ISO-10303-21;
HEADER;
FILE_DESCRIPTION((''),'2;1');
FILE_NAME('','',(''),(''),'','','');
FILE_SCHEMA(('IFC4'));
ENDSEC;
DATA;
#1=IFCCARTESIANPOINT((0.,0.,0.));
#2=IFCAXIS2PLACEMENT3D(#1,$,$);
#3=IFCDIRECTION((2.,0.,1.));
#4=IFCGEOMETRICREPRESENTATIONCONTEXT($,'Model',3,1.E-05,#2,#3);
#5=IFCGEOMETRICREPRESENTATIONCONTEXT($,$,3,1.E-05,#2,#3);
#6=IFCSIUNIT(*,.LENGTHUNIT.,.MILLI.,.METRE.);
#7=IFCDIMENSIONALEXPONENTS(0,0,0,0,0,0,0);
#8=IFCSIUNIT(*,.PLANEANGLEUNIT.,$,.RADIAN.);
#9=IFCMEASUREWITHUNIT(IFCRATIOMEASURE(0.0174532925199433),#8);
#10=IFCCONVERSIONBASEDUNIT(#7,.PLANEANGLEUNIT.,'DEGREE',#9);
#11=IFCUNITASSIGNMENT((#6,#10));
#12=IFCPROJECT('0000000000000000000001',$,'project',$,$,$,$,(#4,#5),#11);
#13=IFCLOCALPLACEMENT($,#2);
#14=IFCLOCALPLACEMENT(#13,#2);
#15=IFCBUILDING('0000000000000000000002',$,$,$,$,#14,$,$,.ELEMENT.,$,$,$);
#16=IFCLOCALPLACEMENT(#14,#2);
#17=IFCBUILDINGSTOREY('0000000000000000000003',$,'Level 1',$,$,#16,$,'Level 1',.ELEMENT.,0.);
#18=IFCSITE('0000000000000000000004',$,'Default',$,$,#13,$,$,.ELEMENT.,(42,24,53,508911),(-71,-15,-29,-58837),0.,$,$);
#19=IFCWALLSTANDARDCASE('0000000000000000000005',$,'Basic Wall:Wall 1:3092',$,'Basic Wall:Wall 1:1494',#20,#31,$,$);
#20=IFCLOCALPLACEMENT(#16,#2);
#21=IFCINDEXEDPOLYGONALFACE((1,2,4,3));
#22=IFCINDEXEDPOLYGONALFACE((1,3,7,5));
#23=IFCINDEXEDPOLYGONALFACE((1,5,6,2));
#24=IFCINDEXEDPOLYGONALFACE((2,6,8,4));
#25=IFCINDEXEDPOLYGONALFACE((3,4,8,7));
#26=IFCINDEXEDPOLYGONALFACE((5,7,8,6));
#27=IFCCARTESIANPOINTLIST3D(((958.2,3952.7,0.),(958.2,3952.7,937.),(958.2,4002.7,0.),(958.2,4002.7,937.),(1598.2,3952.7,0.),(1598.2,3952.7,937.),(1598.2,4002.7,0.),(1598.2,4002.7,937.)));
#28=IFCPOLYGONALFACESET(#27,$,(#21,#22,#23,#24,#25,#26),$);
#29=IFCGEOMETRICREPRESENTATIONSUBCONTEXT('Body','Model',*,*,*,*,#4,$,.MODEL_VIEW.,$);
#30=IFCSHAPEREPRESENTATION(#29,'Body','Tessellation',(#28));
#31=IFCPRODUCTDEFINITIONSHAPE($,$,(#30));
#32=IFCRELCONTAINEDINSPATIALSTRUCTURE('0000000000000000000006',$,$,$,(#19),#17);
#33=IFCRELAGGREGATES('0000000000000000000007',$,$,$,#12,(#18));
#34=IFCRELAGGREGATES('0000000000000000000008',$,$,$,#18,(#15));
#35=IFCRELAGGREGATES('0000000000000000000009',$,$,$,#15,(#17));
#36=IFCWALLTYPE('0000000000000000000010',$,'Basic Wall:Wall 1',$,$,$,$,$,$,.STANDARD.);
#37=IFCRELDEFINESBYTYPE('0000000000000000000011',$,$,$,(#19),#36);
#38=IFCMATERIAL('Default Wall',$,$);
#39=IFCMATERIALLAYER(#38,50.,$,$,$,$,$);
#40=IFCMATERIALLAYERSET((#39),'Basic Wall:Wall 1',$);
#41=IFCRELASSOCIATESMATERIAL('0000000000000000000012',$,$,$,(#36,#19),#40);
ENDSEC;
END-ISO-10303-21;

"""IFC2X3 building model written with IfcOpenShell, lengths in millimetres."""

from ifc_helpers import new_model, entity, si_unit, converted_unit, direction, frame, frame_2d, origin, place, context, subcontext, project, spatial, rectangle, extrude, material, layer, layer_set, layer_usage, type_object, element, save


model = new_model("IFC2X3")

# Units and contexts
model_context = context("Model", 3, precision=1e-05, world=origin(), true_north=direction((2.0, 0.0, 1.0)))
context_of_model = context(None, 3, precision=1e-05, world=origin(), true_north=direction((2.0, 0.0, 1.0)))
body_context = subcontext(model_context, "Body", "Model", "MODEL_VIEW")
ifc_project = project(units=[si_unit("LENGTHUNIT", "METRE", prefix="MILLI"), converted_unit("PLANEANGLEUNIT", "DEGREE", entity("IfcRatioMeasure", 0.0174532925199433), si_unit("PLANEANGLEUNIT", "RADIAN"), dimensions=[0, 0, 0, 0, 0, 0, 0])], contexts=[model_context, context_of_model])

# Site, building, storey
site_placement = place(None, origin())
site = spatial("IfcSite", under=ifc_project, at=site_placement, Name="Default", CompositionType="ELEMENT", RefLatitude=(42, 24, 53, 508911), RefLongitude=(-71, -15, -29, -58837), RefElevation=0.0)
building_placement = place(site_placement, origin())
building = spatial("IfcBuilding", under=site, at=building_placement, CompositionType="ELEMENT")
storey_placement = place(building_placement, origin())
storey = spatial("IfcBuildingStorey", under=building, at=storey_placement, Name="Level 1", LongName="Level 1", CompositionType="ELEMENT", Elevation=0.0)

# Wall
ifc_material = material(Name="Default Wall")
ifc_layer = layer(ifc_material, 50.0)
ifc_layer_set = layer_set([ifc_layer], Name="Basic Wall:Wall 1")
ifc_layer_usage = layer_usage(ifc_layer_set, "AXIS2", "NEGATIVE", 25.0)
wall_type = type_object("IfcWallType", Name="Basic Wall:Wall 1", PredefinedType="STANDARD", material=ifc_layer_set)
wall_placement = place(storey_placement, frame((958.2, 3977.7, 0.0)))
element("IfcWallStandardCase", 1, at=wall_placement, inside=storey, type_object=wall_type, material=ifc_layer_usage, Name="Basic Wall:Wall 1:3092", ObjectType="Basic Wall:Wall 1:1494", context=body_context, shape_type="SweptSolid", body=[
    extrude(rectangle(XDim=640.0, YDim=50.0, at=frame_2d((320.0, 0.0), x_axis=(-1.0, 0.0))), origin(), (0.0, 0.0, 1.0), 937.0),
])

save(model, "model.ifc")
